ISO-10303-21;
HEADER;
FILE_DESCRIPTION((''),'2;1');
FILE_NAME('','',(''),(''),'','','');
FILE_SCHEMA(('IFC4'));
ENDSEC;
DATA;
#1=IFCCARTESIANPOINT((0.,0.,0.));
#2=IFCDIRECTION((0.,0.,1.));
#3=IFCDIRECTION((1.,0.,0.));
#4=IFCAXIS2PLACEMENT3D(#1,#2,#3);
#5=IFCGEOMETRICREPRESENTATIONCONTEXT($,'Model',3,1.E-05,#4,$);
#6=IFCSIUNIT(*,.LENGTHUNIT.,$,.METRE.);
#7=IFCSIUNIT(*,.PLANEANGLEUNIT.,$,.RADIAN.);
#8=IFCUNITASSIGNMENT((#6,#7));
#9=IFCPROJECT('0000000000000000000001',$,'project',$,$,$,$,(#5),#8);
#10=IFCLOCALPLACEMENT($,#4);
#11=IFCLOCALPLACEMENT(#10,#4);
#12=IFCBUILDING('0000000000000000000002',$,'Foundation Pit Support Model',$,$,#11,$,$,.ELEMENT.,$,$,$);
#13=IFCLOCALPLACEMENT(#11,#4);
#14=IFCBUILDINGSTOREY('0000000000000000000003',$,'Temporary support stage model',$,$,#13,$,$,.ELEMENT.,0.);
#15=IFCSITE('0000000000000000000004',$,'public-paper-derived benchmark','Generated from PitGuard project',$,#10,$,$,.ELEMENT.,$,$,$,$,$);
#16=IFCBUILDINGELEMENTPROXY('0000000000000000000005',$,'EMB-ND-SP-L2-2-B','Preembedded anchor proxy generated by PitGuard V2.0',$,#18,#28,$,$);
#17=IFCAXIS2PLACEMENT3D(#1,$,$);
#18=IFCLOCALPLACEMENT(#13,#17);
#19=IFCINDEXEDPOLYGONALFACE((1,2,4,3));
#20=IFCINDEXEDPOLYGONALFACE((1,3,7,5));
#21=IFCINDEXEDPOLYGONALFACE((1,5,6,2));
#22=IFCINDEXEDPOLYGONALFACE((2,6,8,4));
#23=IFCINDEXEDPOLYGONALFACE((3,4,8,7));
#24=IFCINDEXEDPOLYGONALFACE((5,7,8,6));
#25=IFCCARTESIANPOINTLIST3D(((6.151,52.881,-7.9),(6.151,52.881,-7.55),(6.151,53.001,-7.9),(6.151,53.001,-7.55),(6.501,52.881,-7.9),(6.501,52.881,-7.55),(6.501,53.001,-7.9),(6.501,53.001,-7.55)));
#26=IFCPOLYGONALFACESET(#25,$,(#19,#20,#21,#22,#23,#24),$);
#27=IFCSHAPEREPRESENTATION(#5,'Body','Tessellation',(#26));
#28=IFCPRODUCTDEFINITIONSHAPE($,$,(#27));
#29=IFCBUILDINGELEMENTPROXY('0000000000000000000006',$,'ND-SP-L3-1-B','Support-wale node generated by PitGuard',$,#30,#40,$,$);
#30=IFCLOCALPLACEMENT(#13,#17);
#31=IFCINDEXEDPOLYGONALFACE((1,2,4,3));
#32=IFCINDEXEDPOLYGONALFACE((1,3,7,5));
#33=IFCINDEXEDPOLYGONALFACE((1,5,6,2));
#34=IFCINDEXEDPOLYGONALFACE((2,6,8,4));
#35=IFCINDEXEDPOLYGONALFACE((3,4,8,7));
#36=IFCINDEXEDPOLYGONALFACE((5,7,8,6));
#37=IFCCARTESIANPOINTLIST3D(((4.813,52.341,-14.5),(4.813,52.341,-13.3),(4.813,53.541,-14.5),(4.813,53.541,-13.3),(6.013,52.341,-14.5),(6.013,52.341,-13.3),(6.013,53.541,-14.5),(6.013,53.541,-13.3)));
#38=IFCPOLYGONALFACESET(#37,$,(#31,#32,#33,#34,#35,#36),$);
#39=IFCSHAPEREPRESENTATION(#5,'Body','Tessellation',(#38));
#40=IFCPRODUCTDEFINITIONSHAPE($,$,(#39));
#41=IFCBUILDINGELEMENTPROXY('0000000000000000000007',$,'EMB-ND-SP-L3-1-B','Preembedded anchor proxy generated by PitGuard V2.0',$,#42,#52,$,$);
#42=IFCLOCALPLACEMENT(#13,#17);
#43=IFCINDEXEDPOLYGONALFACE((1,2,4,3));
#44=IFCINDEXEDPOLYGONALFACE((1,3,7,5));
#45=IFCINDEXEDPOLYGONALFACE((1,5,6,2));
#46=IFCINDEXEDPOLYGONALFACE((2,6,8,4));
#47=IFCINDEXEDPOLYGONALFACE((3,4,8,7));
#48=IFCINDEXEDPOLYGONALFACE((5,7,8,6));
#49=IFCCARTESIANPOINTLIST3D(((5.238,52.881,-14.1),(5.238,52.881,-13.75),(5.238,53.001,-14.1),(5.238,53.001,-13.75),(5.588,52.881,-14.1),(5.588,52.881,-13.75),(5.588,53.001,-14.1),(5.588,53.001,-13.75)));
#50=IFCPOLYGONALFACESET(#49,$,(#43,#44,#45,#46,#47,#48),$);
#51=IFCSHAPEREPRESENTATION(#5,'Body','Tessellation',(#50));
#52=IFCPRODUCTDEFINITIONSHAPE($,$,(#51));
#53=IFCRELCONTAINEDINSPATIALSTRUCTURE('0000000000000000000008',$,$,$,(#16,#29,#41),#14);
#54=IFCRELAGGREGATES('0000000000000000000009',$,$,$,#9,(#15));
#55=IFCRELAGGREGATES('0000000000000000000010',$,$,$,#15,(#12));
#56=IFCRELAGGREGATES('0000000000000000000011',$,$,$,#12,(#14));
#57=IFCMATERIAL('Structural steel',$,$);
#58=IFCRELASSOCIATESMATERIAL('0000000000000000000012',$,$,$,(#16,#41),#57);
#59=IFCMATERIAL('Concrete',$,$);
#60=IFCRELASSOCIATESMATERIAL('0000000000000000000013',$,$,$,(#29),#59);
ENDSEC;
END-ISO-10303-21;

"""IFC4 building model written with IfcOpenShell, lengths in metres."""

from ifc_helpers import new_model, si_unit, frame, origin_with_axes, origin_2d, place, context, project, spatial, rectangle, extrude, material, element, save


model = new_model("IFC4")

# Units and contexts
model_context = context("Model", 3, precision=1e-05, world=origin_with_axes())
ifc_project = project(units=[si_unit("LENGTHUNIT", "METRE"), si_unit("PLANEANGLEUNIT", "RADIAN")], contexts=[model_context])

# Site, building, storey
site_placement = place(None, origin_with_axes())
site = spatial("IfcSite", under=ifc_project, at=site_placement, Name="public-paper-derived benchmark", Description="Generated from PitGuard project", CompositionType="ELEMENT")
building_placement = place(site_placement, origin_with_axes())
building = spatial("IfcBuilding", under=site, at=building_placement, Name="Foundation Pit Support Model", CompositionType="ELEMENT")
storey_placement = place(building_placement, origin_with_axes())
storey = spatial("IfcBuildingStorey", under=building, at=storey_placement, Name="Temporary support stage model", CompositionType="ELEMENT", Elevation=0.0)

# Shared definitions
ifc_material_1 = material(Name="Structural steel")

# Shared definitions
ifc_material_2 = material(Name="Concrete")

# Building element proxies
proxy_1_placement = place(storey_placement, frame((6.326, 52.941, -7.9), z_axis=(0.0, 0.0, 1.0), x_axis=(1.0, 0.0, 0.0)))
element("IfcBuildingElementProxy", 1, at=proxy_1_placement, inside=storey, material=ifc_material_1, Name="EMB-ND-SP-L2-2-B", Description="Preembedded anchor proxy generated by PitGuard V2.0", context=model_context, shape_type="SweptSolid", body=[
    extrude(rectangle(XDim=0.35, YDim=0.12, at=origin_2d()), origin_with_axes(), (0.0, 0.0, 1.0), 0.35),
])
proxy_2_placement = place(storey_placement, frame((5.413, 52.941, -14.5), z_axis=(0.0, 0.0, 1.0), x_axis=(1.0, 0.0, 0.0)))
element("IfcBuildingElementProxy", 2, at=proxy_2_placement, inside=storey, material=ifc_material_2, Name="ND-SP-L3-1-B", Description="Support-wale node generated by PitGuard", context=model_context, shape_type="SweptSolid", body=[
    extrude(rectangle(XDim=1.2, YDim=1.2, at=origin_2d()), origin_with_axes(), (0.0, 0.0, 1.0), 1.2),
])
proxy_3_placement = place(storey_placement, frame((5.413, 52.941, -14.1), z_axis=(0.0, 0.0, 1.0), x_axis=(1.0, 0.0, 0.0)))
element("IfcBuildingElementProxy", 3, at=proxy_3_placement, inside=storey, material=ifc_material_1, Name="EMB-ND-SP-L3-1-B", Description="Preembedded anchor proxy generated by PitGuard V2.0", context=model_context, shape_type="SweptSolid", body=[
    extrude(rectangle(XDim=0.35, YDim=0.12, at=origin_2d()), origin_with_axes(), (0.0, 0.0, 1.0), 0.35),
])

save(model, "model.ifc")
